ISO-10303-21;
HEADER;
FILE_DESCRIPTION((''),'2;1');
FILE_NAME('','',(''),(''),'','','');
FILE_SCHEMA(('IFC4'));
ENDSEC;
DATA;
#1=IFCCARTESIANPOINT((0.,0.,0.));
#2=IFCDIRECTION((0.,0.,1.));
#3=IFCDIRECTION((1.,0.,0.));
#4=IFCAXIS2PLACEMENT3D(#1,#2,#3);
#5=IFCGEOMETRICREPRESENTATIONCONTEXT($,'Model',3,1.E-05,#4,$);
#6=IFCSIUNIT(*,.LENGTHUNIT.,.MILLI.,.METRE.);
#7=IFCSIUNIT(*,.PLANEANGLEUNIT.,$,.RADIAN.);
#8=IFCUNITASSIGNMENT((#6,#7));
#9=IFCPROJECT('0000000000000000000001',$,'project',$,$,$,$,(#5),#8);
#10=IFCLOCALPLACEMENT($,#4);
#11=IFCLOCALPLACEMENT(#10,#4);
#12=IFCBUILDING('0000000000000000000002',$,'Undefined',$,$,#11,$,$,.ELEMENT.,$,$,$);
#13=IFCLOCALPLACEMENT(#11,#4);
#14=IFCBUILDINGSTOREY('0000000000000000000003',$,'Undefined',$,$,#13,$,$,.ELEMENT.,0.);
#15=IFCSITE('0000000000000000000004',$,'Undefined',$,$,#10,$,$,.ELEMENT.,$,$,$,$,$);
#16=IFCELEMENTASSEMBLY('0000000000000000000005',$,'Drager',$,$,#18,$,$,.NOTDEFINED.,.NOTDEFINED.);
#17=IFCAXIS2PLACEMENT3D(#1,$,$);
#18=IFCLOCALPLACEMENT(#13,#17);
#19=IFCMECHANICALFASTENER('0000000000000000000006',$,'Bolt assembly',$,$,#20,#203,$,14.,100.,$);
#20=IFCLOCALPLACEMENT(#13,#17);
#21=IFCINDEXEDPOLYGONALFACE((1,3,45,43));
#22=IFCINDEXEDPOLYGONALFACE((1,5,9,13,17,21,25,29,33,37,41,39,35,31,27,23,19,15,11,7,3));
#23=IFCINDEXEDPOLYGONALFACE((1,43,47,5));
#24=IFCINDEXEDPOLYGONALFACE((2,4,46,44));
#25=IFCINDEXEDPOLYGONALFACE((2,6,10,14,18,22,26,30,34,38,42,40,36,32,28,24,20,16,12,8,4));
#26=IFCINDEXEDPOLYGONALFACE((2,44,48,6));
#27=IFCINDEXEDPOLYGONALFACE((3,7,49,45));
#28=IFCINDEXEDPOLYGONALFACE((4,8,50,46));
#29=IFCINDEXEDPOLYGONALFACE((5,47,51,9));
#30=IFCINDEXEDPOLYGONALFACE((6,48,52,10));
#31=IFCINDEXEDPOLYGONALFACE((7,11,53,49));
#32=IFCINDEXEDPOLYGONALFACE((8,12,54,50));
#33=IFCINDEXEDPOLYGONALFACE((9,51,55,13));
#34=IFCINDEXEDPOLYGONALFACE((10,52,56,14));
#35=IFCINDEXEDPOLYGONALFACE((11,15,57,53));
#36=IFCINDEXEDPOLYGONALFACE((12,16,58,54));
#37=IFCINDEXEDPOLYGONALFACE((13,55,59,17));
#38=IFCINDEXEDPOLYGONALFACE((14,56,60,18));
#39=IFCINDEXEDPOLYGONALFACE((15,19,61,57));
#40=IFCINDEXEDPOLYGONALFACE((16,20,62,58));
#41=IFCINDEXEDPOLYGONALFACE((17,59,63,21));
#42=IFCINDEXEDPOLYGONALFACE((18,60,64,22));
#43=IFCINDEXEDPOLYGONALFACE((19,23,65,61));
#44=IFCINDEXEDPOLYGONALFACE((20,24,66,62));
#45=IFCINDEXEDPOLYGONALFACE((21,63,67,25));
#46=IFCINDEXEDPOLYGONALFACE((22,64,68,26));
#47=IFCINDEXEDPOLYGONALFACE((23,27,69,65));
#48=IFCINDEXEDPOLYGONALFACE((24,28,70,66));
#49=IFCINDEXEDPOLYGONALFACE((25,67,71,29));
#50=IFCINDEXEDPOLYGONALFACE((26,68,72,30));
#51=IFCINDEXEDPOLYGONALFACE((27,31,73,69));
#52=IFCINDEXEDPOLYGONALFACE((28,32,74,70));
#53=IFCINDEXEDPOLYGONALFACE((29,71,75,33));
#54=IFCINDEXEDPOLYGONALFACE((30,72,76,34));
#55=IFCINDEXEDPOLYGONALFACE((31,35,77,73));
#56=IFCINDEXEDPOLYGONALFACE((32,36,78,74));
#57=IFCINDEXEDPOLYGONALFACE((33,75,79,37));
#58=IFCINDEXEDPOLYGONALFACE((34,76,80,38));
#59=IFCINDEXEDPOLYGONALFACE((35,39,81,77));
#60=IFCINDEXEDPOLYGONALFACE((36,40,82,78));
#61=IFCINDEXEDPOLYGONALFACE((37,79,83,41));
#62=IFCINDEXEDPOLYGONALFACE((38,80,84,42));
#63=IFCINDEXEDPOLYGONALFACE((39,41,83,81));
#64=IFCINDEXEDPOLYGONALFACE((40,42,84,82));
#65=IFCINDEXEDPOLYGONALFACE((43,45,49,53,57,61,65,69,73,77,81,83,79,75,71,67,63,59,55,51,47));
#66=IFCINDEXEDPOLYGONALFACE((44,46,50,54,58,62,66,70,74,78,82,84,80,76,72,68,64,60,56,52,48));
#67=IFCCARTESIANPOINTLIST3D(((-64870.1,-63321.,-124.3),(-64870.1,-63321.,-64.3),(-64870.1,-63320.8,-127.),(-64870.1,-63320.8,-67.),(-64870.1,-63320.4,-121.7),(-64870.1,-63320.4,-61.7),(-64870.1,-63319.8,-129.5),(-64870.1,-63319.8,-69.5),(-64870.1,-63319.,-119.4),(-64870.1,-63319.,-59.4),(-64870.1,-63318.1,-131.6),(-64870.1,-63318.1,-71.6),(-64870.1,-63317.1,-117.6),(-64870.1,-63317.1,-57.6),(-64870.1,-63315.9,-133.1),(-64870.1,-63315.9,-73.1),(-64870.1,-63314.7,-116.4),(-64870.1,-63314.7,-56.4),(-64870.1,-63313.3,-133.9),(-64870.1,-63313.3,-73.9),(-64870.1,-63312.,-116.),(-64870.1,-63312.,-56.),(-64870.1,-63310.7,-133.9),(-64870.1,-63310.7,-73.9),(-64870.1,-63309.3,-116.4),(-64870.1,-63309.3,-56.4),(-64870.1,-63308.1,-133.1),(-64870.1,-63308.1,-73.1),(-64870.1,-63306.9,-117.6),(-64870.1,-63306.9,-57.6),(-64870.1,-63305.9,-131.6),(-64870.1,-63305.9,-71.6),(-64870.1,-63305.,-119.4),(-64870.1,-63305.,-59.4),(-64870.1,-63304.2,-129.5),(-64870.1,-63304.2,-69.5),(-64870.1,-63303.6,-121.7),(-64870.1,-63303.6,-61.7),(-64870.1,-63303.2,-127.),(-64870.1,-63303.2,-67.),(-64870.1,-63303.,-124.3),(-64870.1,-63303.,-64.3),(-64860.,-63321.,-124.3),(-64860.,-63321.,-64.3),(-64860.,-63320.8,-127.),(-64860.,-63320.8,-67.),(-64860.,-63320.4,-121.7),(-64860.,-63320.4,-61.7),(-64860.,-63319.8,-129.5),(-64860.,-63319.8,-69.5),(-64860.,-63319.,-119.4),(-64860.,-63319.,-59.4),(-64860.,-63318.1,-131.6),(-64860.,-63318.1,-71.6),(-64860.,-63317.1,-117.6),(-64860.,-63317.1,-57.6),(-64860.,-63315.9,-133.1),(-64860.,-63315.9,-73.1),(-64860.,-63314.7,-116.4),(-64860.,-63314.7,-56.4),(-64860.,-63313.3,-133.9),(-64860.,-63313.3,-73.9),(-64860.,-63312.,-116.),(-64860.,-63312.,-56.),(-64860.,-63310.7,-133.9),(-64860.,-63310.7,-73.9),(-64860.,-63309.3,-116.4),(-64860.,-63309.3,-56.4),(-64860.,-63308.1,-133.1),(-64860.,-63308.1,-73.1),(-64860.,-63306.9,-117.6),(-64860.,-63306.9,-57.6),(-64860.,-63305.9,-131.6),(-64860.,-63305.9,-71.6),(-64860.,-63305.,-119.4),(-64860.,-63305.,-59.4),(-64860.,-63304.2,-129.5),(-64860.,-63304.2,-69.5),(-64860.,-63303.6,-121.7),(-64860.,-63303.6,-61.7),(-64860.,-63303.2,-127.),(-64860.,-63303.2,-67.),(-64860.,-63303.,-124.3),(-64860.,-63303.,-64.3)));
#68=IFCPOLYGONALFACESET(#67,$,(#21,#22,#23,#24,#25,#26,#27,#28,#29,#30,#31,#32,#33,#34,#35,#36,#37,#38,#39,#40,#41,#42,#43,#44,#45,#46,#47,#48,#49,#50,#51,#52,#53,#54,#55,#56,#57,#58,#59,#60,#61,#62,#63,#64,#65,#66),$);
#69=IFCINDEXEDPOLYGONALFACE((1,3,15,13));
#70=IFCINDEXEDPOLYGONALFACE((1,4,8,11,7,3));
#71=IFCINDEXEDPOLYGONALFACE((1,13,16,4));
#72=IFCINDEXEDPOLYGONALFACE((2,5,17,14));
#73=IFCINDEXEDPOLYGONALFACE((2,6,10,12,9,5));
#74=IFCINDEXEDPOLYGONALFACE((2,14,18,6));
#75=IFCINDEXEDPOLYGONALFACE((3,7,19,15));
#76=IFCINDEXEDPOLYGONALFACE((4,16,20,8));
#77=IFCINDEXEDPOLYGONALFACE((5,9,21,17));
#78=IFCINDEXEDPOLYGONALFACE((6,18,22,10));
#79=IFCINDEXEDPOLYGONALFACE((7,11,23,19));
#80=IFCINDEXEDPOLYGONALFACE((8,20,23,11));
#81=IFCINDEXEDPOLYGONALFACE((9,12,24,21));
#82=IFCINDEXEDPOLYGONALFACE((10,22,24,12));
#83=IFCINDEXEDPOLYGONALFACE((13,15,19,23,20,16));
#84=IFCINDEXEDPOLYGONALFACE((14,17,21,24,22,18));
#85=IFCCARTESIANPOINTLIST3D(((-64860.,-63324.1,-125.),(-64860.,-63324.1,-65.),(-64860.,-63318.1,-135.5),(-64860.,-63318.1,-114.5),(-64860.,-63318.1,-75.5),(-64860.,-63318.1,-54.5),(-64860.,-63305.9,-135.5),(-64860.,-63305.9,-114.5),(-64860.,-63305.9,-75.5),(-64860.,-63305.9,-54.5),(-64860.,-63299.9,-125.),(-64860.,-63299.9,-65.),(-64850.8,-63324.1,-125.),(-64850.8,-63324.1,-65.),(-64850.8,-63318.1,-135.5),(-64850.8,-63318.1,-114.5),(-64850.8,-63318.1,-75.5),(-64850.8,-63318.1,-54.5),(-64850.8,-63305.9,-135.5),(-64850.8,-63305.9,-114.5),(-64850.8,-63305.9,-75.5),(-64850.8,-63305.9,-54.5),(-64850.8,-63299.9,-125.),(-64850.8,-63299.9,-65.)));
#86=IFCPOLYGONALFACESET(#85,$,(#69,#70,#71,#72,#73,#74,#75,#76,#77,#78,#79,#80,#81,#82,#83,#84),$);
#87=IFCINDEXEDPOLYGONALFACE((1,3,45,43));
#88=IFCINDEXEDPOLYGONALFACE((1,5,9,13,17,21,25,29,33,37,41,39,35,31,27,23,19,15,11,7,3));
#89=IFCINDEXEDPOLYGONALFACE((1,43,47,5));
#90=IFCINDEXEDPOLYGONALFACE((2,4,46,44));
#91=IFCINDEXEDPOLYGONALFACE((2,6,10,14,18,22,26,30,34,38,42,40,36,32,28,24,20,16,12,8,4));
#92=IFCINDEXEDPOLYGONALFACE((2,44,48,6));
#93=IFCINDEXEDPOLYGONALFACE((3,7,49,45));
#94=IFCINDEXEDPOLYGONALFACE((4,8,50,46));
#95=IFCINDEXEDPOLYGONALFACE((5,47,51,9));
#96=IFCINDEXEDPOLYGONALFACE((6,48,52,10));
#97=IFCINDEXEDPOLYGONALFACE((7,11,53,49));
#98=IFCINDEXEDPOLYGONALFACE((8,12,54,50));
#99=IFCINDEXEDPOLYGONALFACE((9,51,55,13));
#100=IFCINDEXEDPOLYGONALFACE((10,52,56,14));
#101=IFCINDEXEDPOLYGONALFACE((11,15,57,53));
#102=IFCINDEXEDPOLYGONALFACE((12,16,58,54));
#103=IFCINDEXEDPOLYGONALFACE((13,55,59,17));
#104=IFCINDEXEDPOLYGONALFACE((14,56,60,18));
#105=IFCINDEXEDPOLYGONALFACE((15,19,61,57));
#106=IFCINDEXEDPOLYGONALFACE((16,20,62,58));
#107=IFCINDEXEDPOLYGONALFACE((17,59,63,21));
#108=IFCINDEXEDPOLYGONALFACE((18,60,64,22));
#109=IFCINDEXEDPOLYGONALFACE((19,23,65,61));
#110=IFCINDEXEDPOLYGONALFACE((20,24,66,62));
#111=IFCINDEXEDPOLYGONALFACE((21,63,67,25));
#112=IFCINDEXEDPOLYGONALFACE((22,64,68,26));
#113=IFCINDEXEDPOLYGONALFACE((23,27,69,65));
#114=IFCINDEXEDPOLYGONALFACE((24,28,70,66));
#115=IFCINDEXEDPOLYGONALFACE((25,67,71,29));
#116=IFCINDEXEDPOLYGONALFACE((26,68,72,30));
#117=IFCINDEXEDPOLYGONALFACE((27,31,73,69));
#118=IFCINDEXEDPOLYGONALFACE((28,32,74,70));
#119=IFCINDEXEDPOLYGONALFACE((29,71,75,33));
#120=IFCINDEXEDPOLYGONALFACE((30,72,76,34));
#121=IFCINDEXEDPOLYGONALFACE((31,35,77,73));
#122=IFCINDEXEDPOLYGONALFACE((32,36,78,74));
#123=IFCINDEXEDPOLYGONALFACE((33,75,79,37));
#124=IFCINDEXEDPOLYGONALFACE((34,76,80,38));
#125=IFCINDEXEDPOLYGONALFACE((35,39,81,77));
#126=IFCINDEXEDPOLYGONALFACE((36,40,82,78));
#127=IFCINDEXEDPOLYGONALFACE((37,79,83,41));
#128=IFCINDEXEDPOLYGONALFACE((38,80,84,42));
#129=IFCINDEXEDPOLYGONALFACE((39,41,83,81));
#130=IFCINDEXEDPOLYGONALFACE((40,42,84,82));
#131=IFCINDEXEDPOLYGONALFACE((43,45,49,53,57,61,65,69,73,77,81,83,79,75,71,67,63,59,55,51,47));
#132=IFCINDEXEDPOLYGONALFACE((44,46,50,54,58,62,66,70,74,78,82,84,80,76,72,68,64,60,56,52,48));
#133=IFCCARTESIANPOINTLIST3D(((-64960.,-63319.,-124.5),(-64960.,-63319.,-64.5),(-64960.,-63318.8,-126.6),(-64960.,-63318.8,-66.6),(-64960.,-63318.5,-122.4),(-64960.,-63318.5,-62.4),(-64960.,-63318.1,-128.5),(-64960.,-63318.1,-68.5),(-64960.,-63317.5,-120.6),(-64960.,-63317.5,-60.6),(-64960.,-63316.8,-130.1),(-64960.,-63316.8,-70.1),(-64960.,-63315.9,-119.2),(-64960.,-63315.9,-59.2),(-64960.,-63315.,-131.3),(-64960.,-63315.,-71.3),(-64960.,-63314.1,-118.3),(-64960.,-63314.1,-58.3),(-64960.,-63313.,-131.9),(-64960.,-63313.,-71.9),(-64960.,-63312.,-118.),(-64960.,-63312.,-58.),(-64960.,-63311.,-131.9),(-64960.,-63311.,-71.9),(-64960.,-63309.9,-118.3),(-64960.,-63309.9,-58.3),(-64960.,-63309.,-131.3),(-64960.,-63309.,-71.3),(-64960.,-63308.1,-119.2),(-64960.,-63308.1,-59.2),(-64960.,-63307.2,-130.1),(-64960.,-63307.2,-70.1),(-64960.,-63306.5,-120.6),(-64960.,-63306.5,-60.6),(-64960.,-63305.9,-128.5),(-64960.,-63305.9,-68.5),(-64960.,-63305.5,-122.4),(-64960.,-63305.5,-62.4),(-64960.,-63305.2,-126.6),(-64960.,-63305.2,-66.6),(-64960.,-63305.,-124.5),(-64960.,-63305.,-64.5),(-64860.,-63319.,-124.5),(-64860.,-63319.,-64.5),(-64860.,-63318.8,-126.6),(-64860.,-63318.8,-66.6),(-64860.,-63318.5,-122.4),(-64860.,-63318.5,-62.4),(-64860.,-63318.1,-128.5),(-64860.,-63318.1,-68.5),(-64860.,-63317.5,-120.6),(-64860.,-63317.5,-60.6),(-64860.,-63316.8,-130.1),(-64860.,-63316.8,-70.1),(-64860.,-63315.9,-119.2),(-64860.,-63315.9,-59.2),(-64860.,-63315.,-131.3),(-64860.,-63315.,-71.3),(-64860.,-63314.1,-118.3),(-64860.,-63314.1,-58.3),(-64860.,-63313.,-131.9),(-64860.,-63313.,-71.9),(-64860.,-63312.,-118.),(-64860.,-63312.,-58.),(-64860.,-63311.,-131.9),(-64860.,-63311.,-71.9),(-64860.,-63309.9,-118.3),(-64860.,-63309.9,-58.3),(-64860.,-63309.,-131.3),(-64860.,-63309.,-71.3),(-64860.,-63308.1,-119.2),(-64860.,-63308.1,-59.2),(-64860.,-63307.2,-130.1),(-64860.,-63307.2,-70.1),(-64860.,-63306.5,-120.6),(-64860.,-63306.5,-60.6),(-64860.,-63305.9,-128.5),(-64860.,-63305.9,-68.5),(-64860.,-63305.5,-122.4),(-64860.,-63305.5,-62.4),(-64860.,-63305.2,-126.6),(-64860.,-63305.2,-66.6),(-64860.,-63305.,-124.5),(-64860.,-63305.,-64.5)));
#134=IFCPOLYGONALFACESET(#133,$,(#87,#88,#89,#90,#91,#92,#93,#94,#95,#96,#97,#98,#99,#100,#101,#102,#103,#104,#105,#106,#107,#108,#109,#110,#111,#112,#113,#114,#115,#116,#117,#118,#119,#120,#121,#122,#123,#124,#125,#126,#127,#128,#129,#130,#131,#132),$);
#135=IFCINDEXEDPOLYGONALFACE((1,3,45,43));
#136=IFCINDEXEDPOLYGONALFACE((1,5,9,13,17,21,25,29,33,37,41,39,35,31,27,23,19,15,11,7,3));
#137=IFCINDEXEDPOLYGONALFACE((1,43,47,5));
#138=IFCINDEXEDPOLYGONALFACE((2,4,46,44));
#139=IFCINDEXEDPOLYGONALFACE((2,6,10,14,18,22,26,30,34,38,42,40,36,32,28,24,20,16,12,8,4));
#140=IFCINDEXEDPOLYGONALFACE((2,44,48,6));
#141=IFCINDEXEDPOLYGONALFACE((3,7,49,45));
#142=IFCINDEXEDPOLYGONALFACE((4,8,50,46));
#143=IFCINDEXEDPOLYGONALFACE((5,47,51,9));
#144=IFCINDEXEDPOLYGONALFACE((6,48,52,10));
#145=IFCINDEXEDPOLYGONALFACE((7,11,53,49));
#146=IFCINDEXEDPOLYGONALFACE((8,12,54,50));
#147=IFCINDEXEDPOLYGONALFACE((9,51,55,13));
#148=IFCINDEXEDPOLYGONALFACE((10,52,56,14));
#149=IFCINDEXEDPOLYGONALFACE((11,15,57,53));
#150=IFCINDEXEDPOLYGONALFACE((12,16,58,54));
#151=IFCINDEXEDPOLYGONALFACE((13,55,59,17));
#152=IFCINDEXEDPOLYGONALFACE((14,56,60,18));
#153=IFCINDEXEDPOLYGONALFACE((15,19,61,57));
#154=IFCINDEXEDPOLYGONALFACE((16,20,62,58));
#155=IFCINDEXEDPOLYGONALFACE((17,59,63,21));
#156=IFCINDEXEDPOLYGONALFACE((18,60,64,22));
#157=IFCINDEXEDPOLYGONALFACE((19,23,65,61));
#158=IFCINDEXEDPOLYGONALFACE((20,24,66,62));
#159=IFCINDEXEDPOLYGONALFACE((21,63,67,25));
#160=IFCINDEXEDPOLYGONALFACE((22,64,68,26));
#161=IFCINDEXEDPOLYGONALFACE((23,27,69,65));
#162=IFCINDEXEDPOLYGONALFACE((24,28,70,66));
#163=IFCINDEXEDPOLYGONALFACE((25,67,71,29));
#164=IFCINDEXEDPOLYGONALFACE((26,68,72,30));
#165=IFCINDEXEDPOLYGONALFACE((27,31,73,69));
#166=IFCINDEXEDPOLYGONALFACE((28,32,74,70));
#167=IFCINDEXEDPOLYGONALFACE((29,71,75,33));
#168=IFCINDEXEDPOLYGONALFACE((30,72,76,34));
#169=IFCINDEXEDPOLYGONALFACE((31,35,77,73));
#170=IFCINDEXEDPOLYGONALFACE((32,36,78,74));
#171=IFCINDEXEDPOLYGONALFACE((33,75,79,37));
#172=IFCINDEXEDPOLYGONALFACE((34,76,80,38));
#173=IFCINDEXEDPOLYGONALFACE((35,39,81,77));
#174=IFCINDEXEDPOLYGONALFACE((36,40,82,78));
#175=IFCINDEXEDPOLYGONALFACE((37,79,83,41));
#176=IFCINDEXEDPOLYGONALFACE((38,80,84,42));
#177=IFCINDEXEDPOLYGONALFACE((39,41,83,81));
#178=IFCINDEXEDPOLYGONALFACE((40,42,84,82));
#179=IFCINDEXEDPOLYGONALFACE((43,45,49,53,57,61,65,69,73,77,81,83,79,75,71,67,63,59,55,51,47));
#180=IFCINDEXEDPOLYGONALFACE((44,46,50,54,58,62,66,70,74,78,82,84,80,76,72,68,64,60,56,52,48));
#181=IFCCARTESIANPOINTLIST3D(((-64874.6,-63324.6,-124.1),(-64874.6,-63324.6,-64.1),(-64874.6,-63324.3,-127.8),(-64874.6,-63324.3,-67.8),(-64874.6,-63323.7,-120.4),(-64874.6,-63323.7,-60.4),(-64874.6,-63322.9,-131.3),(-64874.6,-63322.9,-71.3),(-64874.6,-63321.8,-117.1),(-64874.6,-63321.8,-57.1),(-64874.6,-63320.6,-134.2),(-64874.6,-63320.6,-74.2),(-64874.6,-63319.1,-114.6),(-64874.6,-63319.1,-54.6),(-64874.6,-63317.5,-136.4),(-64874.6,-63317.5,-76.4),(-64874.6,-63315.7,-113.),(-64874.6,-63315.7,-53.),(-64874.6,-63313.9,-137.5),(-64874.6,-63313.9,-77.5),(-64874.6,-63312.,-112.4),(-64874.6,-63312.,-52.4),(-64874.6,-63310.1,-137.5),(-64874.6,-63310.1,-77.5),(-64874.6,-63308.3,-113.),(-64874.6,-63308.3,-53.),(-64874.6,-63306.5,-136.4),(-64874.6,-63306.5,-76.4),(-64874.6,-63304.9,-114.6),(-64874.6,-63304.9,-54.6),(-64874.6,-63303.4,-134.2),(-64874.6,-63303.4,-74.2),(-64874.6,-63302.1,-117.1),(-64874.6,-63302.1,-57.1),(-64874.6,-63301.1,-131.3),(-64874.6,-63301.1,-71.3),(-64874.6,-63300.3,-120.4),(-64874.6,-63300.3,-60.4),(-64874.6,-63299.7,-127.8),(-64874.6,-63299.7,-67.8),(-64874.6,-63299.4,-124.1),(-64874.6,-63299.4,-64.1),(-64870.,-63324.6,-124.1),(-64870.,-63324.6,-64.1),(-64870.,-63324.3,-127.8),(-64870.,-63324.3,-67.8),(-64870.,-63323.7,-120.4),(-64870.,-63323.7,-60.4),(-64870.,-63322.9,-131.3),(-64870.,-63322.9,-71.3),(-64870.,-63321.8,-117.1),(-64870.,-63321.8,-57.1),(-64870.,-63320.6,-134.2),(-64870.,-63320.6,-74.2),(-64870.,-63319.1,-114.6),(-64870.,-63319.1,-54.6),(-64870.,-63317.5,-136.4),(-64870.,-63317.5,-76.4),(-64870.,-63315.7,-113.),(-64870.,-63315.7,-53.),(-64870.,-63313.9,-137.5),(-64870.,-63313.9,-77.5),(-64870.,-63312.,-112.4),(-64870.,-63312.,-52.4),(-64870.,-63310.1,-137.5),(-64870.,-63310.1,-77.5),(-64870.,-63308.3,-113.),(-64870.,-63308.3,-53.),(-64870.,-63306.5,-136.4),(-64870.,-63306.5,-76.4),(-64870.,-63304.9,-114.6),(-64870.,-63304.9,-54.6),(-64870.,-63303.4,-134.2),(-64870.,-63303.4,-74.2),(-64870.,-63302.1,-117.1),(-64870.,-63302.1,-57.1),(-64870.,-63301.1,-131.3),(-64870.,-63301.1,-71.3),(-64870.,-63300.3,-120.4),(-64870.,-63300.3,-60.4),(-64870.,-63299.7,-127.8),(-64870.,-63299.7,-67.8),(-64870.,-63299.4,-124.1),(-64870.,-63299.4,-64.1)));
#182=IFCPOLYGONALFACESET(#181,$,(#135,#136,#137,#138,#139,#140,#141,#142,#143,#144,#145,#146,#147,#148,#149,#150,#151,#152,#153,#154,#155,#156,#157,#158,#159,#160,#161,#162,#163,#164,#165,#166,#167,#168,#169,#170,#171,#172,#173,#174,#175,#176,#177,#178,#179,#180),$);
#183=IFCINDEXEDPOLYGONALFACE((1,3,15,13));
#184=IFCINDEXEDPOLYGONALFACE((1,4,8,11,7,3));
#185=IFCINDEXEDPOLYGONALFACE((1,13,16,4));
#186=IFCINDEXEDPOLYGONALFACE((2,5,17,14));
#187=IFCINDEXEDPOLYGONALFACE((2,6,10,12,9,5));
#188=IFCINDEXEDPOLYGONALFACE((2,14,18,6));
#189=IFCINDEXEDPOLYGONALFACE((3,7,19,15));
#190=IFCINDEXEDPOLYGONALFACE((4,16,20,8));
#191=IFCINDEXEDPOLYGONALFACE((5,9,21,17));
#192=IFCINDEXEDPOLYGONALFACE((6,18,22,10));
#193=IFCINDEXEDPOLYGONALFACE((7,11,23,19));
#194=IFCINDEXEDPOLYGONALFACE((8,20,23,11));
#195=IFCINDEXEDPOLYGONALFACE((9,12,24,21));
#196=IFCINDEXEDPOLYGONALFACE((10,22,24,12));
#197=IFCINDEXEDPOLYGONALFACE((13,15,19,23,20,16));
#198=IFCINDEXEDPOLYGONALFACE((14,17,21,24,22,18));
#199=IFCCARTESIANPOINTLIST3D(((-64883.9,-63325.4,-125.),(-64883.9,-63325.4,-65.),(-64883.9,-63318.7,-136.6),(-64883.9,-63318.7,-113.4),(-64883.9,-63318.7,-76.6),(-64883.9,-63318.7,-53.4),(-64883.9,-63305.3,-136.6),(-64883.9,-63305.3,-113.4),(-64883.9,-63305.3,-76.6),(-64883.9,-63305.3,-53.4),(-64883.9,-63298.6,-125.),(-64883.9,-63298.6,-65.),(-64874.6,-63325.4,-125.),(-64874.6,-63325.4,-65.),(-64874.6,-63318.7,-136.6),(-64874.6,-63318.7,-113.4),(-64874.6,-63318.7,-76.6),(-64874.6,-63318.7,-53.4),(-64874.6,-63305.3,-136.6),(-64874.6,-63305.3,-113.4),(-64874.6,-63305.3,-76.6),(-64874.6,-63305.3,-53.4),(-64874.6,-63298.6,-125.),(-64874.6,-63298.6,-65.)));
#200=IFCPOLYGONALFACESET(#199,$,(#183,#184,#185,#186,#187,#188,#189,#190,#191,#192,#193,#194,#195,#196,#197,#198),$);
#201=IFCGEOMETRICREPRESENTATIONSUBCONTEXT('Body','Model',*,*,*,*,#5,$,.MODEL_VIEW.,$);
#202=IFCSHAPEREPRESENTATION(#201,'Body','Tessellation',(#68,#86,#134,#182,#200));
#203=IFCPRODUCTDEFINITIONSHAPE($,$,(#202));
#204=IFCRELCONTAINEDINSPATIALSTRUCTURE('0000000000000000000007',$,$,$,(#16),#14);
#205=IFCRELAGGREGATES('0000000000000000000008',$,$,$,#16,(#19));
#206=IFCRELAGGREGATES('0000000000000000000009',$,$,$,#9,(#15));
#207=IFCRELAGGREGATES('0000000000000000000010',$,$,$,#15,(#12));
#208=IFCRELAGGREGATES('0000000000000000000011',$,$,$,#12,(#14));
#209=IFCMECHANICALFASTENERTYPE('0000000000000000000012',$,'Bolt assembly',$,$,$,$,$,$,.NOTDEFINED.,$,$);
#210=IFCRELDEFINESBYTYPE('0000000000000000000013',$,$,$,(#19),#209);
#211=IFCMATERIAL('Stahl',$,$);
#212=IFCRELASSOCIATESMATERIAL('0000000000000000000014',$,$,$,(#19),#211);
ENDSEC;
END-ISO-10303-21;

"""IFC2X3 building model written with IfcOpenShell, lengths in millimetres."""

from ifc_helpers import new_model, si_unit, frame, origin_with_axes, origin_2d_with_axis, place, context, subcontext, project, spatial, polyline, circle, outline, extrude, source, transform, mapped, material, type_object, element, aggregate, save


model = new_model("IFC2X3")

# Units and contexts
model_context = context("Model", 3, precision=1e-05, world=origin_with_axes())
body_context = subcontext(model_context, "Body", "Model", "MODEL_VIEW")
ifc_project = project(units=[si_unit("LENGTHUNIT", "METRE", prefix="MILLI"), si_unit("PLANEANGLEUNIT", "RADIAN")], contexts=[model_context])

# Site, building, storey
site_placement = place(None, origin_with_axes())
site = spatial("IfcSite", under=ifc_project, at=site_placement, Name="Undefined", CompositionType="ELEMENT")
building_placement = place(site_placement, origin_with_axes())
building = spatial("IfcBuilding", under=site, at=building_placement, Name="Undefined", CompositionType="ELEMENT")
storey_placement = place(building_placement, origin_with_axes())
storey = spatial("IfcBuildingStorey", under=building, at=storey_placement, Name="Undefined", CompositionType="ELEMENT", Elevation=0.0)

# Element assembly
assembly_1_placement = place(storey_placement, origin_with_axes())
assembly_1 = element("IfcElementAssembly", 1, at=assembly_1_placement, inside=storey, Name="Drager", AssemblyPlace="NOTDEFINED", PredefinedType="NOTDEFINED")

# Shared definitions
mechanical_fastener_type = type_object("IfcMechanicalFastenerType", Name="Bolt assembly")
ifc_material_1 = material(Name="Stahl")

# Mechanical fastener
shared_shape_1 = source(origin_with_axes(), body_context, "Body", "SweptSolid", [
    extrude(circle(Radius=9.0, at=origin_2d_with_axis()), frame((0.0, 0.0, 0.0), z_axis=(0.0, 1.0, 0.0), x_axis=(1.0, 0.0, 0.0)), (0.0, 0.0, 1.0), 10.1),
    extrude(outline(polyline([(10.5, -6.1), (10.5, 6.1), (0.0, 12.1), (-10.5, 6.1), (-10.5, -6.1), (0.0, -12.1), (10.5, -6.1)])), frame((0.0, -9.2, 0.0), z_axis=(0.0, 1.0, 0.0), x_axis=(1.0, 0.0, 0.0)), (0.0, 0.0, 1.0), 9.2),
    extrude(circle(Radius=7.0, at=origin_2d_with_axis()), frame((0.0, 0.0, 0.0), z_axis=(0.0, 1.0, 0.0), x_axis=(1.0, 0.0, 0.0)), (0.0, 0.0, 1.0), 100.0),
    extrude(circle(Radius=12.6, at=origin_2d_with_axis()), frame((0.0, 10.0, 0.0), z_axis=(0.0, 1.0, 0.0), x_axis=(1.0, 0.0, 0.0)), (0.0, 0.0, 1.0), 4.6),
    extrude(outline(polyline([(11.6, -6.7), (11.6, 6.7), (0.0, 13.4), (-11.6, 6.7), (-11.6, -6.7), (0.0, -13.4), (11.6, -6.7)])), frame((0.0, 14.6, 0.0), z_axis=(0.0, 1.0, 0.0), x_axis=(1.0, 0.0, 0.0)), (0.0, 0.0, 1.0), 9.2),
])
mechanical_fastener_1_placement = place(assembly_1_placement, frame((-64860.0, -63312.0, -125.0), z_axis=(0.0, -1.0, 0.0), x_axis=(0.0, 0.0, 1.0)))
mechanical_fastener_1 = element("IfcMechanicalFastener", 2, at=mechanical_fastener_1_placement, type_object=mechanical_fastener_type, material=ifc_material_1, Name="Bolt assembly", NominalDiameter=14.0, NominalLength=100.0, context=body_context, shape_type="MappedRepresentation", body=[
    mapped(shared_shape_1, transform((0.0, 0.0, 0.0))),
    mapped(shared_shape_1, transform((60.0, 0.0, 0.0))),
])
aggregate(assembly_1, [mechanical_fastener_1])

save(model, "model.ifc")
